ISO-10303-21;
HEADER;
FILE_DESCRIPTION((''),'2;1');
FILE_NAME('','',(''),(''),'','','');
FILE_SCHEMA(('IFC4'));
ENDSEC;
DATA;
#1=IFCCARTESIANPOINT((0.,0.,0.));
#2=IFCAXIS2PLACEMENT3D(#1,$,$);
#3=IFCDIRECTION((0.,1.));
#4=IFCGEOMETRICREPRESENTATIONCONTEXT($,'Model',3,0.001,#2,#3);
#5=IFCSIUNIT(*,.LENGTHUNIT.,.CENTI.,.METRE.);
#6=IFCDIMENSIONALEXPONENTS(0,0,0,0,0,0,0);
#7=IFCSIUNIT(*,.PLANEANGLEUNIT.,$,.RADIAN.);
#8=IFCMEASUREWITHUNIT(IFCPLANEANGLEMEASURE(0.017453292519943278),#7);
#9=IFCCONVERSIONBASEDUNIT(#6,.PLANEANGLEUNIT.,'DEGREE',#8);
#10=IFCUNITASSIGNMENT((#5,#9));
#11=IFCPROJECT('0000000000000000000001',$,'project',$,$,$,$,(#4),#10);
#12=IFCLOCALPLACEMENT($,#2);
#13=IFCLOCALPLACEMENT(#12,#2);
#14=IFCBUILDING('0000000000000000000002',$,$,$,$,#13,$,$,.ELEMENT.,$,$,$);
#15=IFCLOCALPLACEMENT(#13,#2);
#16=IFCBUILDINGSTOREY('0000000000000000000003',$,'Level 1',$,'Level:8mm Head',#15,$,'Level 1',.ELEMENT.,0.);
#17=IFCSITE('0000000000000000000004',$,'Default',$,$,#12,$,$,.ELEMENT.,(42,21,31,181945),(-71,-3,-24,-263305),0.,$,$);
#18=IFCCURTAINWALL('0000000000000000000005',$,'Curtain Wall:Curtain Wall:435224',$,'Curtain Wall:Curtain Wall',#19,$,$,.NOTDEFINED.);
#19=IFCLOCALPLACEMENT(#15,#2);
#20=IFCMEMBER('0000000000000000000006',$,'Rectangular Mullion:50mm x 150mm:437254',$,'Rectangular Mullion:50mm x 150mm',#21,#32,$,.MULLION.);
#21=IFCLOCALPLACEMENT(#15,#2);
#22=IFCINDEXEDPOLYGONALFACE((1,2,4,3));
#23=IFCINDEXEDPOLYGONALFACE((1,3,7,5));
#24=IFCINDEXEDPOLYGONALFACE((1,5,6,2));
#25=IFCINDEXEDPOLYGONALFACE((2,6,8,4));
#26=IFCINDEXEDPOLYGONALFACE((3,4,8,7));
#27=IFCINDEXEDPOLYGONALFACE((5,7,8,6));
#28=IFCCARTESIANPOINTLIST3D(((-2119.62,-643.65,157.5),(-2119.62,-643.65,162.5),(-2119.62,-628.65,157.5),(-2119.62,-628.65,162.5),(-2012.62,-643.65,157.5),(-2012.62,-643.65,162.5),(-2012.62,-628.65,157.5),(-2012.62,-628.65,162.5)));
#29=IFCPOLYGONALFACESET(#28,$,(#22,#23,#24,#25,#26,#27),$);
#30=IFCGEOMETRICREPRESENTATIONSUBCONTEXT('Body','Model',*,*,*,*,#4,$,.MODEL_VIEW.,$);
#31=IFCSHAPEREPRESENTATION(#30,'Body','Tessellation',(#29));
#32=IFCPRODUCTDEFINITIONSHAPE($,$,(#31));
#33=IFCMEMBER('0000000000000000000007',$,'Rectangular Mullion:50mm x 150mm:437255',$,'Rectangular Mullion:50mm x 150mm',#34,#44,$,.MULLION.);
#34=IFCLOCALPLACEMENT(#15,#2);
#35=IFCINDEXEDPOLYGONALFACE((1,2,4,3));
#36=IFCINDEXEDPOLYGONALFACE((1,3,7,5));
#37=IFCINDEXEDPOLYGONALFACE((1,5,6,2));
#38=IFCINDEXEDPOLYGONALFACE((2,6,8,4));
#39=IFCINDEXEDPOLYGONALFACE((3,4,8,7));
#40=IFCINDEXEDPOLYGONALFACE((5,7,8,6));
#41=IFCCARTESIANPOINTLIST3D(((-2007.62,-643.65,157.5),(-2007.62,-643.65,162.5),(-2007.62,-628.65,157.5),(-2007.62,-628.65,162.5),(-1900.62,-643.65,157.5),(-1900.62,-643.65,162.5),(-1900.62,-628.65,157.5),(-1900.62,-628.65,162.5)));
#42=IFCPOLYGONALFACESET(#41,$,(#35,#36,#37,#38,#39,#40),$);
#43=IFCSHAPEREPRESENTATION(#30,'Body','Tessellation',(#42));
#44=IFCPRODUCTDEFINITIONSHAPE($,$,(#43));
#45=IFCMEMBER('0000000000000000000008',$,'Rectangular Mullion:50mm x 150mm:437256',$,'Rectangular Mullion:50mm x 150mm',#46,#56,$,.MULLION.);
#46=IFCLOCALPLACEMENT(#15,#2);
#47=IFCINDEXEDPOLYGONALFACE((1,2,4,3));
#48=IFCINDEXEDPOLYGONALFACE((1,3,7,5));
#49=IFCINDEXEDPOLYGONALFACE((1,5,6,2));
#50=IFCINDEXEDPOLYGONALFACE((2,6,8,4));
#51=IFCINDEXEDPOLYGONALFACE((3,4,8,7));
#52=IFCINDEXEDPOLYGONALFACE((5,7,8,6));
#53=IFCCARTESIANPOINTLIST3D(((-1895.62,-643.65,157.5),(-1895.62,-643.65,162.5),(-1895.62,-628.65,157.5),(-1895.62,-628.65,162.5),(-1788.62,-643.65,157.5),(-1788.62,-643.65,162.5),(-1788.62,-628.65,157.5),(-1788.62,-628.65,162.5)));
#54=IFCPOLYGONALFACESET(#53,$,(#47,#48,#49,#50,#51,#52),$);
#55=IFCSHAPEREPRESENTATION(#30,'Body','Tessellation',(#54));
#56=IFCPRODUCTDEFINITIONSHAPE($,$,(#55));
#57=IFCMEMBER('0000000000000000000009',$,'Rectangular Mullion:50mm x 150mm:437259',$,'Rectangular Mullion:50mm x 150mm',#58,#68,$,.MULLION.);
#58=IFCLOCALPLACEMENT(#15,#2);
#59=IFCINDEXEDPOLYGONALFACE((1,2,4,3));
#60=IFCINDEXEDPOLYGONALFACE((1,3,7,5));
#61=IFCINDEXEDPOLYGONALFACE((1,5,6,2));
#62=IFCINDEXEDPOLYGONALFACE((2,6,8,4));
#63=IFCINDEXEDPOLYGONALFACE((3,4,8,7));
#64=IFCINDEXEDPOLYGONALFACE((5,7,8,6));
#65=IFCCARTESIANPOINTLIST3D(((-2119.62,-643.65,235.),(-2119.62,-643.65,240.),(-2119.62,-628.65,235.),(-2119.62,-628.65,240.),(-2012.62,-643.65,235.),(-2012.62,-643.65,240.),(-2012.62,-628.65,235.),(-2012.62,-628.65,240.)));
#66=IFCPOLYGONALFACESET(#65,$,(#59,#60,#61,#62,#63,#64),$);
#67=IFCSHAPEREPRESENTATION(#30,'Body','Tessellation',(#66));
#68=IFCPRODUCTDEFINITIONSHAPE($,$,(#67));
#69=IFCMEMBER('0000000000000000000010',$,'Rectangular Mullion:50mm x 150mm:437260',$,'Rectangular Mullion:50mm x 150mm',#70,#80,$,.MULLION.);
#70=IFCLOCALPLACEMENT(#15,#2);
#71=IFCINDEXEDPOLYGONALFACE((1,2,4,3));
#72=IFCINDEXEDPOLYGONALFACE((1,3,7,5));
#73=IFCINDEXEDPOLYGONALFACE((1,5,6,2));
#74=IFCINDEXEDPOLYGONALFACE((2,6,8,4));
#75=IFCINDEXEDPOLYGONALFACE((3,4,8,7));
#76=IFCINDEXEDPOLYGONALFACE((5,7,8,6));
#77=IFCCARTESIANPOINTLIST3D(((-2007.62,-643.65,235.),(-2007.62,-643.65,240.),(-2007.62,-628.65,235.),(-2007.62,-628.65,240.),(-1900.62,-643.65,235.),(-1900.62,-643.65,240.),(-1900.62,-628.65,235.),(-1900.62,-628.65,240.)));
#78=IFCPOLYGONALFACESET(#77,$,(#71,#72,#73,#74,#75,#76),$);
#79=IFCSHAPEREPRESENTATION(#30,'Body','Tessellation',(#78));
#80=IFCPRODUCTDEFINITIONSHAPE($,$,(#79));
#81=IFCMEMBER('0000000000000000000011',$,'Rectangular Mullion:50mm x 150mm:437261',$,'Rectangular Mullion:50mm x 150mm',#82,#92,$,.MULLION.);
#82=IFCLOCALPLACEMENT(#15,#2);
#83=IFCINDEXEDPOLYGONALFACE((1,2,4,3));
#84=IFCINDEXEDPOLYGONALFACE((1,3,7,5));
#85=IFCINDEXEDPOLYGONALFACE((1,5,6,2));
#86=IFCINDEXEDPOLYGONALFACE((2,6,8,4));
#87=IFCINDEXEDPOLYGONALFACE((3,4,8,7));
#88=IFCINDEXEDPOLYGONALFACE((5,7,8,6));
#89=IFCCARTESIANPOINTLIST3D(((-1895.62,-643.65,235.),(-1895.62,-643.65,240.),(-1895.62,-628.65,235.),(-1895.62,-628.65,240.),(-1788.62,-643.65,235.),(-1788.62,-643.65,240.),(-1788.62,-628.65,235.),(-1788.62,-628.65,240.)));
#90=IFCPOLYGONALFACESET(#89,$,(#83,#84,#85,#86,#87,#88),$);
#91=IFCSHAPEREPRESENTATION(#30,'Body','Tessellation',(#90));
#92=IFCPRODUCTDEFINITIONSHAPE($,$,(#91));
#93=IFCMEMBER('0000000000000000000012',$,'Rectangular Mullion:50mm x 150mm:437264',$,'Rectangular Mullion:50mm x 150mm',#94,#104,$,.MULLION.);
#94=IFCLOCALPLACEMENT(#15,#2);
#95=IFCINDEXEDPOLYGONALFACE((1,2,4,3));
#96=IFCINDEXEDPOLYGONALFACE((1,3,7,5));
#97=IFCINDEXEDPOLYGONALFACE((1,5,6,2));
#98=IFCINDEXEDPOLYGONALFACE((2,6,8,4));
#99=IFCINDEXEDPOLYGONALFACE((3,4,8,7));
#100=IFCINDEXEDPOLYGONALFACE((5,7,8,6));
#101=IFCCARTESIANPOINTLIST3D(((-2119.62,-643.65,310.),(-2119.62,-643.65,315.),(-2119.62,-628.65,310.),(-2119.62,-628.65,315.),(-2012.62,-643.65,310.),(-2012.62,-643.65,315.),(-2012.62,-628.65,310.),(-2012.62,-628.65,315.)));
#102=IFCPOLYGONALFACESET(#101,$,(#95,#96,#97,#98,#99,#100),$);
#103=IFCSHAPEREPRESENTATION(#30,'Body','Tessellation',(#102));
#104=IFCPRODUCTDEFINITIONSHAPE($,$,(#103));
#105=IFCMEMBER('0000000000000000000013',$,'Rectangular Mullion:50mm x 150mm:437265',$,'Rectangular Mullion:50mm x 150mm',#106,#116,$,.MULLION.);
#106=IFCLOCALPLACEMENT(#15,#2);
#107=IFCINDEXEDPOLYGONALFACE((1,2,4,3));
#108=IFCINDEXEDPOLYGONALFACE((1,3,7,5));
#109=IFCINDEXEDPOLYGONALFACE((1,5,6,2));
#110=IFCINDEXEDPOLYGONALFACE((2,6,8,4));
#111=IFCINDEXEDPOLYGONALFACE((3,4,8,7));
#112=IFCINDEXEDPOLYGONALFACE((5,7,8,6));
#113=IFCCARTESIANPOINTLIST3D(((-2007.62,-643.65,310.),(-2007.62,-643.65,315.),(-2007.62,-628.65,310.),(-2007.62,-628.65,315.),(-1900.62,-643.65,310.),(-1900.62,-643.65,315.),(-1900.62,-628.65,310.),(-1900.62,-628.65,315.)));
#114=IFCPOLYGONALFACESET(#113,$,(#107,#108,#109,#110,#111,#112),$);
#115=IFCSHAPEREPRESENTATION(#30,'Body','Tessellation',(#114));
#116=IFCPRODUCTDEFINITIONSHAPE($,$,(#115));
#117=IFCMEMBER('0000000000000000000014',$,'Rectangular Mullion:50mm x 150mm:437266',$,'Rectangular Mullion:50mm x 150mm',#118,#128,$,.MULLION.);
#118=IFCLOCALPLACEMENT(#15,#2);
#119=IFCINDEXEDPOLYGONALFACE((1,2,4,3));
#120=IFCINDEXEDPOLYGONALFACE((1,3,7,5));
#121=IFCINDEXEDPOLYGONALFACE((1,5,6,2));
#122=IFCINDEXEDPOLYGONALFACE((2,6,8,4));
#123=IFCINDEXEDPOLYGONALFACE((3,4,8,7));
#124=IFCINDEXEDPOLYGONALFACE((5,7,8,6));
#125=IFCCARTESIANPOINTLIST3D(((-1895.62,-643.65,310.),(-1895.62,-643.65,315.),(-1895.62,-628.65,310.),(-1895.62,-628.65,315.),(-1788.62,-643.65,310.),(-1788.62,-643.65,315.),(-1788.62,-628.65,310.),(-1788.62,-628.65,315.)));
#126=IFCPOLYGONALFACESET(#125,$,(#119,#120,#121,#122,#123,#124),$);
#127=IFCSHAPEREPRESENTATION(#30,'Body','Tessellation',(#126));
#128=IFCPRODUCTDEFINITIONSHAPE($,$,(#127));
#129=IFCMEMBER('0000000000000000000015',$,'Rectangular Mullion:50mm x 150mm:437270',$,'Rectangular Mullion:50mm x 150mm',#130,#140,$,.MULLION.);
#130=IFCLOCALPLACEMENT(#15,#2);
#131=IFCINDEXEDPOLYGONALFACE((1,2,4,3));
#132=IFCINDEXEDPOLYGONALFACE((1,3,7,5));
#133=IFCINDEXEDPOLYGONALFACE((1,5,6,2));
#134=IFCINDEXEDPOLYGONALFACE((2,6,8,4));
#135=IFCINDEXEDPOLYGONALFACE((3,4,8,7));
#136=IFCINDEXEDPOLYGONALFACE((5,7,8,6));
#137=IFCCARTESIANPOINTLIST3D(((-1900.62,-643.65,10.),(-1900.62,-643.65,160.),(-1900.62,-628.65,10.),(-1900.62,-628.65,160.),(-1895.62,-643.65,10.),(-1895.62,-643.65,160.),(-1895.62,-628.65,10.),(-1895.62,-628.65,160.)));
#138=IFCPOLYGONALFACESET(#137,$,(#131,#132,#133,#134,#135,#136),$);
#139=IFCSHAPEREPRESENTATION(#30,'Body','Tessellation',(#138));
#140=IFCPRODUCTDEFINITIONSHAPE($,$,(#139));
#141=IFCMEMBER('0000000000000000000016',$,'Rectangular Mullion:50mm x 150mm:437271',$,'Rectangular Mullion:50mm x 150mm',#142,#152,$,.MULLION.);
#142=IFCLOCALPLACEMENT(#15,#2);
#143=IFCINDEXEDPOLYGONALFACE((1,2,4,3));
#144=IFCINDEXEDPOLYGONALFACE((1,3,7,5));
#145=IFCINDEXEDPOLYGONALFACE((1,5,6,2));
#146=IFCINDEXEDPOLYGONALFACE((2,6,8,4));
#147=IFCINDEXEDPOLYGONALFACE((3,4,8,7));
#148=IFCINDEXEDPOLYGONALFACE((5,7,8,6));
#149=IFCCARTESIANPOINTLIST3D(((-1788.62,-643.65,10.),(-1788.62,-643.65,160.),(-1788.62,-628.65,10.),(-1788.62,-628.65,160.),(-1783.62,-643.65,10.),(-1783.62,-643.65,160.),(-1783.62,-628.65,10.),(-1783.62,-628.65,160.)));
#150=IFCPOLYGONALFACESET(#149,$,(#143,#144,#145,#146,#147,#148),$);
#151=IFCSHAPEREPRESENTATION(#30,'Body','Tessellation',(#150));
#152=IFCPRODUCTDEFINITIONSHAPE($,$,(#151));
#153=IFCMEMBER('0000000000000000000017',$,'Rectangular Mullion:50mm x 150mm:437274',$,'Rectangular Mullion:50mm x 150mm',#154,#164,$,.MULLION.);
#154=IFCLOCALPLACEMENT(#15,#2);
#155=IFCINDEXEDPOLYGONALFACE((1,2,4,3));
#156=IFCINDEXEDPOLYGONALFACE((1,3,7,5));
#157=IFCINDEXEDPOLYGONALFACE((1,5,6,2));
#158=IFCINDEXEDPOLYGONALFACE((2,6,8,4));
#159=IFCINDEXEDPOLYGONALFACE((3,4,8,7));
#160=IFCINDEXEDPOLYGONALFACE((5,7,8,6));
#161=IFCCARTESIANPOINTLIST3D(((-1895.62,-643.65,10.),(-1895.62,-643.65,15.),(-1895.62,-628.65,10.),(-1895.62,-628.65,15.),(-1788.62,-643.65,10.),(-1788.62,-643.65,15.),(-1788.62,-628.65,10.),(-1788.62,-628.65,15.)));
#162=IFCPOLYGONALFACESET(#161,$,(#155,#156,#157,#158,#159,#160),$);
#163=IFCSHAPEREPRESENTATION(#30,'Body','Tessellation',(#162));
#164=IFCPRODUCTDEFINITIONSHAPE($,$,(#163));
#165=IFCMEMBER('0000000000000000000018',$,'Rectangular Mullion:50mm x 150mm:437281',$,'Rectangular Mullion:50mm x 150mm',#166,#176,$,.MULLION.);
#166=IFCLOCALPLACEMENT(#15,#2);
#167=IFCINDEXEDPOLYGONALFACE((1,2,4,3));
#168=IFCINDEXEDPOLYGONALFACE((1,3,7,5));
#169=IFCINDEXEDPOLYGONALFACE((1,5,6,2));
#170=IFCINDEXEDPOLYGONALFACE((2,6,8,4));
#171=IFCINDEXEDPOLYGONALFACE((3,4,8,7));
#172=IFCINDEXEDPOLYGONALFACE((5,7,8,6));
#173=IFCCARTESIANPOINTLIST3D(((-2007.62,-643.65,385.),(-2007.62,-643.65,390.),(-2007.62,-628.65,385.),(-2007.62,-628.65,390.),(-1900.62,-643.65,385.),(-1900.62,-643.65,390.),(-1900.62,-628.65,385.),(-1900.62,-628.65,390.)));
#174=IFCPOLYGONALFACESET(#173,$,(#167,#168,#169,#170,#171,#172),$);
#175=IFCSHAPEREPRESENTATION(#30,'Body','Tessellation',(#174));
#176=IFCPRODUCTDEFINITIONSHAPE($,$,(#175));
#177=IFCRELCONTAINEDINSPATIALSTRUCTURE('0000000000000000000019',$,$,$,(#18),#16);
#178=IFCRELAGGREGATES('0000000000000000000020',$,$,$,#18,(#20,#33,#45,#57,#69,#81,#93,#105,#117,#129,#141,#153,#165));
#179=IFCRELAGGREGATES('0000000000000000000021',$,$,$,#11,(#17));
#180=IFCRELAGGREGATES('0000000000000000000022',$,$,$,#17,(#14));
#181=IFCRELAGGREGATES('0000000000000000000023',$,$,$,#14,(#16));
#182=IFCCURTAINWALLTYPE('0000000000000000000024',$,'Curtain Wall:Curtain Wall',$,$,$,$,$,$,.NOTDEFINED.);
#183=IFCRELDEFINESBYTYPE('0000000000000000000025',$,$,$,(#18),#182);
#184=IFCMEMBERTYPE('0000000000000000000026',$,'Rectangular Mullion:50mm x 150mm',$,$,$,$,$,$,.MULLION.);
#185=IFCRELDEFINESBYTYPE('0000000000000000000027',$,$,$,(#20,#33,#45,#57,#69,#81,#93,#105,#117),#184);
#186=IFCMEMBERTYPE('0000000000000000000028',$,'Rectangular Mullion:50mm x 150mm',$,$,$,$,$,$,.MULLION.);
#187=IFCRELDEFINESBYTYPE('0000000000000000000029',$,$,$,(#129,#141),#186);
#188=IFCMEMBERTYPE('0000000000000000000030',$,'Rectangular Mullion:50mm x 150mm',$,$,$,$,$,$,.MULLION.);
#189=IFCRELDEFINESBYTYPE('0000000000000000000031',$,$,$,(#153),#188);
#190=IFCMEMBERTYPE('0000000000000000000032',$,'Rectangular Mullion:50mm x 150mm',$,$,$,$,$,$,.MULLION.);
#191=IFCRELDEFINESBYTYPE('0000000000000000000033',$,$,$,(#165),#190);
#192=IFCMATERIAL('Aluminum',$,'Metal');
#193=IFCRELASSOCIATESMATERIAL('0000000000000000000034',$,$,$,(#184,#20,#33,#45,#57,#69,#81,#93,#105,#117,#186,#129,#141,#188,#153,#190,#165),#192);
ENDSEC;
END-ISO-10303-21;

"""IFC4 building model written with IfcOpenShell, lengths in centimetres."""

from ifc_helpers import new_model, entity, si_unit, converted_unit, direction, frame, origin, place, context, subcontext, project, spatial, indexed_curve, outline, extrude, source, transform, mapped, material, type_object, type_shapes, element, aggregate, save


model = new_model("IFC4")

# Units and contexts
model_context = context("Model", 3, precision=0.001, world=origin(), true_north=direction((0.0, 1.0)))
body_context = subcontext(model_context, "Body", "Model", "MODEL_VIEW")
ifc_project = project(units=[si_unit("LENGTHUNIT", "METRE", prefix="CENTI"), converted_unit("PLANEANGLEUNIT", "DEGREE", entity("IfcPlaneAngleMeasure", 0.017453292519943278), si_unit("PLANEANGLEUNIT", "RADIAN"), dimensions=[0, 0, 0, 0, 0, 0, 0])], contexts=[model_context])

# Site, building, storey
site_placement = place(None, origin())
site = spatial("IfcSite", under=ifc_project, at=site_placement, Name="Default", CompositionType="ELEMENT", RefLatitude=(42, 21, 31, 181945), RefLongitude=(-71, -3, -24, -263305), RefElevation=0.0)
building_placement = place(site_placement, origin())
building = spatial("IfcBuilding", under=site, at=building_placement, CompositionType="ELEMENT")
storey_placement = place(building_placement, origin())
storey = spatial("IfcBuildingStorey", under=building, at=storey_placement, Name="Level 1", ObjectType="Level:8mm Head", LongName="Level 1", CompositionType="ELEMENT", Elevation=0.0)

# Curtain wall, members
curtain_wall_type = type_object("IfcCurtainWallType", Name="Curtain Wall:Curtain Wall", PredefinedType="NOTDEFINED")
curtain_wall_placement = place(storey_placement, origin())
curtain_wall = element("IfcCurtainWall", 1, at=curtain_wall_placement, inside=storey, type_object=curtain_wall_type, Name="Curtain Wall:Curtain Wall:435224", ObjectType="Curtain Wall:Curtain Wall", PredefinedType="NOTDEFINED")
ifc_material_1 = material(Name="Aluminum", Category="Metal")
member_type_1 = type_object("IfcMemberType", Name="Rectangular Mullion:50mm x 150mm", PredefinedType="MULLION", material=ifc_material_1)
shared_shape_1 = source(origin(), body_context, "Body", "SweptSolid", [
    extrude(outline(indexed_curve([(-2.5, -7.5), (2.5, -7.5), (2.5, 7.5), (-2.5, 7.5), (-2.5, -7.5)], self_intersect=False)), frame((0.0, 0.0, -107.0), z_axis=(0.0, 0.0, 1.0), x_axis=(-1.0, 0.0, 0.0)), (0.0, 0.0, 1.0), 107.0),
])
type_shapes(member_type_1, [shared_shape_1])
member_1_placement = place(curtain_wall_placement, frame((-2012.62, -636.15, 160.0), z_axis=(1.0, 0.0, 0.0), x_axis=(0.0, 0.0, 1.0)))
member_1 = element("IfcMember", 2, at=member_1_placement, type_object=member_type_1, material=ifc_material_1, Name="Rectangular Mullion:50mm x 150mm:437254", ObjectType="Rectangular Mullion:50mm x 150mm", PredefinedType="MULLION", context=body_context, shape_type="MappedRepresentation", body=[
    mapped(shared_shape_1, transform((0.0, 0.0, 0.0), scale=1.0)),
])
member_2_placement = place(curtain_wall_placement, frame((-1900.62, -636.15, 160.0), z_axis=(1.0, 0.0, 0.0), x_axis=(0.0, 0.0, 1.0)))
member_2 = element("IfcMember", 3, at=member_2_placement, type_object=member_type_1, material=ifc_material_1, Name="Rectangular Mullion:50mm x 150mm:437255", ObjectType="Rectangular Mullion:50mm x 150mm", PredefinedType="MULLION", context=body_context, shape_type="MappedRepresentation", body=[
    mapped(shared_shape_1, transform((0.0, 0.0, 0.0), scale=1.0)),
])
member_3_placement = place(curtain_wall_placement, frame((-1788.62, -636.15, 160.0), z_axis=(1.0, 0.0, 0.0), x_axis=(0.0, 0.0, 1.0)))
member_3 = element("IfcMember", 4, at=member_3_placement, type_object=member_type_1, material=ifc_material_1, Name="Rectangular Mullion:50mm x 150mm:437256", ObjectType="Rectangular Mullion:50mm x 150mm", PredefinedType="MULLION", context=body_context, shape_type="MappedRepresentation", body=[
    mapped(shared_shape_1, transform((0.0, 0.0, 0.0), scale=1.0)),
])
member_4_placement = place(curtain_wall_placement, frame((-2012.62, -636.15, 237.5), z_axis=(1.0, 0.0, 0.0), x_axis=(0.0, 0.0, 1.0)))
member_4 = element("IfcMember", 5, at=member_4_placement, type_object=member_type_1, material=ifc_material_1, Name="Rectangular Mullion:50mm x 150mm:437259", ObjectType="Rectangular Mullion:50mm x 150mm", PredefinedType="MULLION", context=body_context, shape_type="MappedRepresentation", body=[
    mapped(shared_shape_1, transform((0.0, 0.0, 0.0), scale=1.0)),
])
member_5_placement = place(curtain_wall_placement, frame((-1900.62, -636.15, 237.5), z_axis=(1.0, 0.0, 0.0), x_axis=(0.0, 0.0, 1.0)))
member_5 = element("IfcMember", 6, at=member_5_placement, type_object=member_type_1, material=ifc_material_1, Name="Rectangular Mullion:50mm x 150mm:437260", ObjectType="Rectangular Mullion:50mm x 150mm", PredefinedType="MULLION", context=body_context, shape_type="MappedRepresentation", body=[
    mapped(shared_shape_1, transform((0.0, 0.0, 0.0), scale=1.0)),
])
member_6_placement = place(curtain_wall_placement, frame((-1788.62, -636.15, 237.5), z_axis=(1.0, 0.0, 0.0), x_axis=(0.0, 0.0, 1.0)))
member_6 = element("IfcMember", 7, at=member_6_placement, type_object=member_type_1, material=ifc_material_1, Name="Rectangular Mullion:50mm x 150mm:437261", ObjectType="Rectangular Mullion:50mm x 150mm", PredefinedType="MULLION", context=body_context, shape_type="MappedRepresentation", body=[
    mapped(shared_shape_1, transform((0.0, 0.0, 0.0), scale=1.0)),
])
member_7_placement = place(curtain_wall_placement, frame((-2012.62, -636.15, 312.5), z_axis=(1.0, 0.0, 0.0), x_axis=(0.0, 0.0, 1.0)))
member_7 = element("IfcMember", 8, at=member_7_placement, type_object=member_type_1, material=ifc_material_1, Name="Rectangular Mullion:50mm x 150mm:437264", ObjectType="Rectangular Mullion:50mm x 150mm", PredefinedType="MULLION", context=body_context, shape_type="MappedRepresentation", body=[
    mapped(shared_shape_1, transform((0.0, 0.0, 0.0), scale=1.0)),
])
member_8_placement = place(curtain_wall_placement, frame((-1900.62, -636.15, 312.5), z_axis=(1.0, 0.0, 0.0), x_axis=(0.0, 0.0, 1.0)))
member_8 = element("IfcMember", 9, at=member_8_placement, type_object=member_type_1, material=ifc_material_1, Name="Rectangular Mullion:50mm x 150mm:437265", ObjectType="Rectangular Mullion:50mm x 150mm", PredefinedType="MULLION", context=body_context, shape_type="MappedRepresentation", body=[
    mapped(shared_shape_1, transform((0.0, 0.0, 0.0), scale=1.0)),
])
member_9_placement = place(curtain_wall_placement, frame((-1788.62, -636.15, 312.5), z_axis=(1.0, 0.0, 0.0), x_axis=(0.0, 0.0, 1.0)))
member_9 = element("IfcMember", 10, at=member_9_placement, type_object=member_type_1, material=ifc_material_1, Name="Rectangular Mullion:50mm x 150mm:437266", ObjectType="Rectangular Mullion:50mm x 150mm", PredefinedType="MULLION", context=body_context, shape_type="MappedRepresentation", body=[
    mapped(shared_shape_1, transform((0.0, 0.0, 0.0), scale=1.0)),
])
member_type_2 = type_object("IfcMemberType", Name="Rectangular Mullion:50mm x 150mm", PredefinedType="MULLION", material=ifc_material_1)
shared_shape_2 = source(origin(), body_context, "Body", "SweptSolid", [
    extrude(outline(indexed_curve([(-2.5, -7.5), (2.5, -7.5), (2.5, 7.5), (-2.5, 7.5), (-2.5, -7.5)], self_intersect=False)), frame((0.0, 0.0, -150.0), z_axis=(0.0, 0.0, 1.0), x_axis=(-1.0, 0.0, 0.0)), (0.0, 0.0, 1.0), 150.0),
])
type_shapes(member_type_2, [shared_shape_2])
member_10_placement = place(curtain_wall_placement, frame((-1898.12, -636.15, 10.0), z_axis=(0.0, 0.0, -1.0), x_axis=(1.0, 0.0, 0.0)))
member_10 = element("IfcMember", 11, at=member_10_placement, type_object=member_type_2, material=ifc_material_1, Name="Rectangular Mullion:50mm x 150mm:437270", ObjectType="Rectangular Mullion:50mm x 150mm", PredefinedType="MULLION", context=body_context, shape_type="MappedRepresentation", body=[
    mapped(shared_shape_2, transform((0.0, 0.0, 0.0), scale=1.0)),
])
member_11_placement = place(curtain_wall_placement, frame((-1786.12, -636.15, 10.0), z_axis=(0.0, 0.0, -1.0), x_axis=(1.0, 0.0, 0.0)))
member_11 = element("IfcMember", 12, at=member_11_placement, type_object=member_type_2, material=ifc_material_1, Name="Rectangular Mullion:50mm x 150mm:437271", ObjectType="Rectangular Mullion:50mm x 150mm", PredefinedType="MULLION", context=body_context, shape_type="MappedRepresentation", body=[
    mapped(shared_shape_2, transform((0.0, 0.0, 0.0), scale=1.0)),
])
member_type_3 = type_object("IfcMemberType", Name="Rectangular Mullion:50mm x 150mm", PredefinedType="MULLION", material=ifc_material_1)
shared_shape_3 = source(origin(), body_context, "Body", "SweptSolid", [
    extrude(outline(indexed_curve([(-2.5, -7.5), (2.5, -7.5), (2.5, 7.5), (-2.5, 7.5), (-2.5, -7.5)], self_intersect=False)), frame((-2.5, 0.0, -107.0), z_axis=(0.0, 0.0, 1.0), x_axis=(-1.0, 0.0, 0.0)), (0.0, 0.0, 1.0), 107.0),
])
type_shapes(member_type_3, [shared_shape_3])
member_12_placement = place(curtain_wall_placement, frame((-1895.62, -636.15, 10.0), z_axis=(-1.0, 0.0, 0.0), x_axis=(0.0, 0.0, -1.0)))
member_12 = element("IfcMember", 13, at=member_12_placement, type_object=member_type_3, material=ifc_material_1, Name="Rectangular Mullion:50mm x 150mm:437274", ObjectType="Rectangular Mullion:50mm x 150mm", PredefinedType="MULLION", context=body_context, shape_type="MappedRepresentation", body=[
    mapped(shared_shape_3, transform((0.0, 0.0, 0.0), scale=1.0)),
])
member_type_4 = type_object("IfcMemberType", Name="Rectangular Mullion:50mm x 150mm", PredefinedType="MULLION", material=ifc_material_1)
shared_shape_4 = source(origin(), body_context, "Body", "SweptSolid", [
    extrude(outline(indexed_curve([(-2.5, -7.5), (2.5, -7.5), (2.5, 7.5), (-2.5, 7.5), (-2.5, -7.5)], self_intersect=False)), frame((-2.5, 0.0, -107.0), z_axis=(0.0, 0.0, 1.0), x_axis=(-1.0, 0.0, 0.0)), (0.0, 0.0, 1.0), 107.0),
])
type_shapes(member_type_4, [shared_shape_4])
member_13_placement = place(curtain_wall_placement, frame((-1900.62, -636.15, 390.0), z_axis=(1.0, 0.0, 0.0), x_axis=(0.0, 0.0, 1.0)))
member_13 = element("IfcMember", 14, at=member_13_placement, type_object=member_type_4, material=ifc_material_1, Name="Rectangular Mullion:50mm x 150mm:437281", ObjectType="Rectangular Mullion:50mm x 150mm", PredefinedType="MULLION", context=body_context, shape_type="MappedRepresentation", body=[
    mapped(shared_shape_4, transform((0.0, 0.0, 0.0), scale=1.0)),
])
aggregate(curtain_wall, [member_1, member_2, member_3, member_4, member_5, member_6, member_7, member_8, member_9, member_10, member_11, member_12, member_13])

save(model, "model.ifc")
